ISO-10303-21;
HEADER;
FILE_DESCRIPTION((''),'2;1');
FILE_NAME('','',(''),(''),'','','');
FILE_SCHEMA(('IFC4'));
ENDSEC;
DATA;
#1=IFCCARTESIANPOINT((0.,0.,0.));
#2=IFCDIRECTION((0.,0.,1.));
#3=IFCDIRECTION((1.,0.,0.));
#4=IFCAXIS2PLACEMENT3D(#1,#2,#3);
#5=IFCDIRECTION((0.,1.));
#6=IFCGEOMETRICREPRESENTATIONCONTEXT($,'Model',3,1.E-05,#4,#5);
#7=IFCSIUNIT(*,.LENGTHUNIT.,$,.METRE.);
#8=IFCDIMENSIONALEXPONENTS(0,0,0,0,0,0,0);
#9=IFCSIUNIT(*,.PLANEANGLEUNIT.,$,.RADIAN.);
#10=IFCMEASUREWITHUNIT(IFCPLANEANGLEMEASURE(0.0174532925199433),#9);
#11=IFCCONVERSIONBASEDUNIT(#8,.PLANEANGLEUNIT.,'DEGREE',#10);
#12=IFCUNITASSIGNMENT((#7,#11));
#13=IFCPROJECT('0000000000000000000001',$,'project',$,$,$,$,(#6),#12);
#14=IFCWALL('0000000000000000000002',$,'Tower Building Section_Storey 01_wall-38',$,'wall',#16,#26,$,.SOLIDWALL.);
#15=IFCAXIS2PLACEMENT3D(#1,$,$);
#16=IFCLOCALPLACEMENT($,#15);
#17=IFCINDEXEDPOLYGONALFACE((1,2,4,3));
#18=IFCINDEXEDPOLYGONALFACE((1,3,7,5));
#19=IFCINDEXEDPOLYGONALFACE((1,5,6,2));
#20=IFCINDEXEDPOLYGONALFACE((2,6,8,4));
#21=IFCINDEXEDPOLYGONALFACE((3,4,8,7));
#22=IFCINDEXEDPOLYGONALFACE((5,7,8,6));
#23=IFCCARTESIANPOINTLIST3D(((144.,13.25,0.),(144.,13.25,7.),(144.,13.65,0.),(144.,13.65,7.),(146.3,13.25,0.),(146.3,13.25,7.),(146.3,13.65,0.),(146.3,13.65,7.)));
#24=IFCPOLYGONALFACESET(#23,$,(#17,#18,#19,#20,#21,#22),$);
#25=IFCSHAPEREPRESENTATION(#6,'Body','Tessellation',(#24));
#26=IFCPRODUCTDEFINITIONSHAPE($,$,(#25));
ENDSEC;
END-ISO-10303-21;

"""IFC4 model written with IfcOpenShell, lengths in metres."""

from ifc_helpers import new_model, entity, si_unit, converted_unit, direction, frame, origin_with_axes, place, context, project, polyline, outline, extrude, element, save


model = new_model("IFC4")

# Units and contexts
model_context = context("Model", 3, precision=1e-05, world=origin_with_axes(), true_north=direction((0.0, 1.0)))
ifc_project = project(units=[si_unit("LENGTHUNIT", "METRE"), converted_unit("PLANEANGLEUNIT", "DEGREE", entity("IfcPlaneAngleMeasure", 0.0174532925199433), si_unit("PLANEANGLEUNIT", "RADIAN"), dimensions=[0, 0, 0, 0, 0, 0, 0])], contexts=[model_context])

# Shared definitions
placement_1 = place(None, origin_with_axes())
placement_2 = place(placement_1, origin_with_axes())

# Wall
wall_1_placement = place(placement_2, frame((145.15, 13.25, 3.5), z_axis=(0.0, 1.0, 0.0), x_axis=(0.0, 0.0, 1.0)))
element("IfcWall", 1, at=wall_1_placement, Name="Tower Building Section_Storey 01_wall-38", ObjectType="wall", PredefinedType="SOLIDWALL", context=model_context, body=[
    extrude(outline(polyline([(-3.5, -1.15, 0.0), (3.5, -1.15, 0.0), (3.5, 1.15, 0.0), (-3.5, 1.15, 0.0), (-3.5, -1.15, 0.0)])), origin_with_axes(), (0.0, 0.0, 1.0), 0.4),
])

save(model, "model.ifc")
